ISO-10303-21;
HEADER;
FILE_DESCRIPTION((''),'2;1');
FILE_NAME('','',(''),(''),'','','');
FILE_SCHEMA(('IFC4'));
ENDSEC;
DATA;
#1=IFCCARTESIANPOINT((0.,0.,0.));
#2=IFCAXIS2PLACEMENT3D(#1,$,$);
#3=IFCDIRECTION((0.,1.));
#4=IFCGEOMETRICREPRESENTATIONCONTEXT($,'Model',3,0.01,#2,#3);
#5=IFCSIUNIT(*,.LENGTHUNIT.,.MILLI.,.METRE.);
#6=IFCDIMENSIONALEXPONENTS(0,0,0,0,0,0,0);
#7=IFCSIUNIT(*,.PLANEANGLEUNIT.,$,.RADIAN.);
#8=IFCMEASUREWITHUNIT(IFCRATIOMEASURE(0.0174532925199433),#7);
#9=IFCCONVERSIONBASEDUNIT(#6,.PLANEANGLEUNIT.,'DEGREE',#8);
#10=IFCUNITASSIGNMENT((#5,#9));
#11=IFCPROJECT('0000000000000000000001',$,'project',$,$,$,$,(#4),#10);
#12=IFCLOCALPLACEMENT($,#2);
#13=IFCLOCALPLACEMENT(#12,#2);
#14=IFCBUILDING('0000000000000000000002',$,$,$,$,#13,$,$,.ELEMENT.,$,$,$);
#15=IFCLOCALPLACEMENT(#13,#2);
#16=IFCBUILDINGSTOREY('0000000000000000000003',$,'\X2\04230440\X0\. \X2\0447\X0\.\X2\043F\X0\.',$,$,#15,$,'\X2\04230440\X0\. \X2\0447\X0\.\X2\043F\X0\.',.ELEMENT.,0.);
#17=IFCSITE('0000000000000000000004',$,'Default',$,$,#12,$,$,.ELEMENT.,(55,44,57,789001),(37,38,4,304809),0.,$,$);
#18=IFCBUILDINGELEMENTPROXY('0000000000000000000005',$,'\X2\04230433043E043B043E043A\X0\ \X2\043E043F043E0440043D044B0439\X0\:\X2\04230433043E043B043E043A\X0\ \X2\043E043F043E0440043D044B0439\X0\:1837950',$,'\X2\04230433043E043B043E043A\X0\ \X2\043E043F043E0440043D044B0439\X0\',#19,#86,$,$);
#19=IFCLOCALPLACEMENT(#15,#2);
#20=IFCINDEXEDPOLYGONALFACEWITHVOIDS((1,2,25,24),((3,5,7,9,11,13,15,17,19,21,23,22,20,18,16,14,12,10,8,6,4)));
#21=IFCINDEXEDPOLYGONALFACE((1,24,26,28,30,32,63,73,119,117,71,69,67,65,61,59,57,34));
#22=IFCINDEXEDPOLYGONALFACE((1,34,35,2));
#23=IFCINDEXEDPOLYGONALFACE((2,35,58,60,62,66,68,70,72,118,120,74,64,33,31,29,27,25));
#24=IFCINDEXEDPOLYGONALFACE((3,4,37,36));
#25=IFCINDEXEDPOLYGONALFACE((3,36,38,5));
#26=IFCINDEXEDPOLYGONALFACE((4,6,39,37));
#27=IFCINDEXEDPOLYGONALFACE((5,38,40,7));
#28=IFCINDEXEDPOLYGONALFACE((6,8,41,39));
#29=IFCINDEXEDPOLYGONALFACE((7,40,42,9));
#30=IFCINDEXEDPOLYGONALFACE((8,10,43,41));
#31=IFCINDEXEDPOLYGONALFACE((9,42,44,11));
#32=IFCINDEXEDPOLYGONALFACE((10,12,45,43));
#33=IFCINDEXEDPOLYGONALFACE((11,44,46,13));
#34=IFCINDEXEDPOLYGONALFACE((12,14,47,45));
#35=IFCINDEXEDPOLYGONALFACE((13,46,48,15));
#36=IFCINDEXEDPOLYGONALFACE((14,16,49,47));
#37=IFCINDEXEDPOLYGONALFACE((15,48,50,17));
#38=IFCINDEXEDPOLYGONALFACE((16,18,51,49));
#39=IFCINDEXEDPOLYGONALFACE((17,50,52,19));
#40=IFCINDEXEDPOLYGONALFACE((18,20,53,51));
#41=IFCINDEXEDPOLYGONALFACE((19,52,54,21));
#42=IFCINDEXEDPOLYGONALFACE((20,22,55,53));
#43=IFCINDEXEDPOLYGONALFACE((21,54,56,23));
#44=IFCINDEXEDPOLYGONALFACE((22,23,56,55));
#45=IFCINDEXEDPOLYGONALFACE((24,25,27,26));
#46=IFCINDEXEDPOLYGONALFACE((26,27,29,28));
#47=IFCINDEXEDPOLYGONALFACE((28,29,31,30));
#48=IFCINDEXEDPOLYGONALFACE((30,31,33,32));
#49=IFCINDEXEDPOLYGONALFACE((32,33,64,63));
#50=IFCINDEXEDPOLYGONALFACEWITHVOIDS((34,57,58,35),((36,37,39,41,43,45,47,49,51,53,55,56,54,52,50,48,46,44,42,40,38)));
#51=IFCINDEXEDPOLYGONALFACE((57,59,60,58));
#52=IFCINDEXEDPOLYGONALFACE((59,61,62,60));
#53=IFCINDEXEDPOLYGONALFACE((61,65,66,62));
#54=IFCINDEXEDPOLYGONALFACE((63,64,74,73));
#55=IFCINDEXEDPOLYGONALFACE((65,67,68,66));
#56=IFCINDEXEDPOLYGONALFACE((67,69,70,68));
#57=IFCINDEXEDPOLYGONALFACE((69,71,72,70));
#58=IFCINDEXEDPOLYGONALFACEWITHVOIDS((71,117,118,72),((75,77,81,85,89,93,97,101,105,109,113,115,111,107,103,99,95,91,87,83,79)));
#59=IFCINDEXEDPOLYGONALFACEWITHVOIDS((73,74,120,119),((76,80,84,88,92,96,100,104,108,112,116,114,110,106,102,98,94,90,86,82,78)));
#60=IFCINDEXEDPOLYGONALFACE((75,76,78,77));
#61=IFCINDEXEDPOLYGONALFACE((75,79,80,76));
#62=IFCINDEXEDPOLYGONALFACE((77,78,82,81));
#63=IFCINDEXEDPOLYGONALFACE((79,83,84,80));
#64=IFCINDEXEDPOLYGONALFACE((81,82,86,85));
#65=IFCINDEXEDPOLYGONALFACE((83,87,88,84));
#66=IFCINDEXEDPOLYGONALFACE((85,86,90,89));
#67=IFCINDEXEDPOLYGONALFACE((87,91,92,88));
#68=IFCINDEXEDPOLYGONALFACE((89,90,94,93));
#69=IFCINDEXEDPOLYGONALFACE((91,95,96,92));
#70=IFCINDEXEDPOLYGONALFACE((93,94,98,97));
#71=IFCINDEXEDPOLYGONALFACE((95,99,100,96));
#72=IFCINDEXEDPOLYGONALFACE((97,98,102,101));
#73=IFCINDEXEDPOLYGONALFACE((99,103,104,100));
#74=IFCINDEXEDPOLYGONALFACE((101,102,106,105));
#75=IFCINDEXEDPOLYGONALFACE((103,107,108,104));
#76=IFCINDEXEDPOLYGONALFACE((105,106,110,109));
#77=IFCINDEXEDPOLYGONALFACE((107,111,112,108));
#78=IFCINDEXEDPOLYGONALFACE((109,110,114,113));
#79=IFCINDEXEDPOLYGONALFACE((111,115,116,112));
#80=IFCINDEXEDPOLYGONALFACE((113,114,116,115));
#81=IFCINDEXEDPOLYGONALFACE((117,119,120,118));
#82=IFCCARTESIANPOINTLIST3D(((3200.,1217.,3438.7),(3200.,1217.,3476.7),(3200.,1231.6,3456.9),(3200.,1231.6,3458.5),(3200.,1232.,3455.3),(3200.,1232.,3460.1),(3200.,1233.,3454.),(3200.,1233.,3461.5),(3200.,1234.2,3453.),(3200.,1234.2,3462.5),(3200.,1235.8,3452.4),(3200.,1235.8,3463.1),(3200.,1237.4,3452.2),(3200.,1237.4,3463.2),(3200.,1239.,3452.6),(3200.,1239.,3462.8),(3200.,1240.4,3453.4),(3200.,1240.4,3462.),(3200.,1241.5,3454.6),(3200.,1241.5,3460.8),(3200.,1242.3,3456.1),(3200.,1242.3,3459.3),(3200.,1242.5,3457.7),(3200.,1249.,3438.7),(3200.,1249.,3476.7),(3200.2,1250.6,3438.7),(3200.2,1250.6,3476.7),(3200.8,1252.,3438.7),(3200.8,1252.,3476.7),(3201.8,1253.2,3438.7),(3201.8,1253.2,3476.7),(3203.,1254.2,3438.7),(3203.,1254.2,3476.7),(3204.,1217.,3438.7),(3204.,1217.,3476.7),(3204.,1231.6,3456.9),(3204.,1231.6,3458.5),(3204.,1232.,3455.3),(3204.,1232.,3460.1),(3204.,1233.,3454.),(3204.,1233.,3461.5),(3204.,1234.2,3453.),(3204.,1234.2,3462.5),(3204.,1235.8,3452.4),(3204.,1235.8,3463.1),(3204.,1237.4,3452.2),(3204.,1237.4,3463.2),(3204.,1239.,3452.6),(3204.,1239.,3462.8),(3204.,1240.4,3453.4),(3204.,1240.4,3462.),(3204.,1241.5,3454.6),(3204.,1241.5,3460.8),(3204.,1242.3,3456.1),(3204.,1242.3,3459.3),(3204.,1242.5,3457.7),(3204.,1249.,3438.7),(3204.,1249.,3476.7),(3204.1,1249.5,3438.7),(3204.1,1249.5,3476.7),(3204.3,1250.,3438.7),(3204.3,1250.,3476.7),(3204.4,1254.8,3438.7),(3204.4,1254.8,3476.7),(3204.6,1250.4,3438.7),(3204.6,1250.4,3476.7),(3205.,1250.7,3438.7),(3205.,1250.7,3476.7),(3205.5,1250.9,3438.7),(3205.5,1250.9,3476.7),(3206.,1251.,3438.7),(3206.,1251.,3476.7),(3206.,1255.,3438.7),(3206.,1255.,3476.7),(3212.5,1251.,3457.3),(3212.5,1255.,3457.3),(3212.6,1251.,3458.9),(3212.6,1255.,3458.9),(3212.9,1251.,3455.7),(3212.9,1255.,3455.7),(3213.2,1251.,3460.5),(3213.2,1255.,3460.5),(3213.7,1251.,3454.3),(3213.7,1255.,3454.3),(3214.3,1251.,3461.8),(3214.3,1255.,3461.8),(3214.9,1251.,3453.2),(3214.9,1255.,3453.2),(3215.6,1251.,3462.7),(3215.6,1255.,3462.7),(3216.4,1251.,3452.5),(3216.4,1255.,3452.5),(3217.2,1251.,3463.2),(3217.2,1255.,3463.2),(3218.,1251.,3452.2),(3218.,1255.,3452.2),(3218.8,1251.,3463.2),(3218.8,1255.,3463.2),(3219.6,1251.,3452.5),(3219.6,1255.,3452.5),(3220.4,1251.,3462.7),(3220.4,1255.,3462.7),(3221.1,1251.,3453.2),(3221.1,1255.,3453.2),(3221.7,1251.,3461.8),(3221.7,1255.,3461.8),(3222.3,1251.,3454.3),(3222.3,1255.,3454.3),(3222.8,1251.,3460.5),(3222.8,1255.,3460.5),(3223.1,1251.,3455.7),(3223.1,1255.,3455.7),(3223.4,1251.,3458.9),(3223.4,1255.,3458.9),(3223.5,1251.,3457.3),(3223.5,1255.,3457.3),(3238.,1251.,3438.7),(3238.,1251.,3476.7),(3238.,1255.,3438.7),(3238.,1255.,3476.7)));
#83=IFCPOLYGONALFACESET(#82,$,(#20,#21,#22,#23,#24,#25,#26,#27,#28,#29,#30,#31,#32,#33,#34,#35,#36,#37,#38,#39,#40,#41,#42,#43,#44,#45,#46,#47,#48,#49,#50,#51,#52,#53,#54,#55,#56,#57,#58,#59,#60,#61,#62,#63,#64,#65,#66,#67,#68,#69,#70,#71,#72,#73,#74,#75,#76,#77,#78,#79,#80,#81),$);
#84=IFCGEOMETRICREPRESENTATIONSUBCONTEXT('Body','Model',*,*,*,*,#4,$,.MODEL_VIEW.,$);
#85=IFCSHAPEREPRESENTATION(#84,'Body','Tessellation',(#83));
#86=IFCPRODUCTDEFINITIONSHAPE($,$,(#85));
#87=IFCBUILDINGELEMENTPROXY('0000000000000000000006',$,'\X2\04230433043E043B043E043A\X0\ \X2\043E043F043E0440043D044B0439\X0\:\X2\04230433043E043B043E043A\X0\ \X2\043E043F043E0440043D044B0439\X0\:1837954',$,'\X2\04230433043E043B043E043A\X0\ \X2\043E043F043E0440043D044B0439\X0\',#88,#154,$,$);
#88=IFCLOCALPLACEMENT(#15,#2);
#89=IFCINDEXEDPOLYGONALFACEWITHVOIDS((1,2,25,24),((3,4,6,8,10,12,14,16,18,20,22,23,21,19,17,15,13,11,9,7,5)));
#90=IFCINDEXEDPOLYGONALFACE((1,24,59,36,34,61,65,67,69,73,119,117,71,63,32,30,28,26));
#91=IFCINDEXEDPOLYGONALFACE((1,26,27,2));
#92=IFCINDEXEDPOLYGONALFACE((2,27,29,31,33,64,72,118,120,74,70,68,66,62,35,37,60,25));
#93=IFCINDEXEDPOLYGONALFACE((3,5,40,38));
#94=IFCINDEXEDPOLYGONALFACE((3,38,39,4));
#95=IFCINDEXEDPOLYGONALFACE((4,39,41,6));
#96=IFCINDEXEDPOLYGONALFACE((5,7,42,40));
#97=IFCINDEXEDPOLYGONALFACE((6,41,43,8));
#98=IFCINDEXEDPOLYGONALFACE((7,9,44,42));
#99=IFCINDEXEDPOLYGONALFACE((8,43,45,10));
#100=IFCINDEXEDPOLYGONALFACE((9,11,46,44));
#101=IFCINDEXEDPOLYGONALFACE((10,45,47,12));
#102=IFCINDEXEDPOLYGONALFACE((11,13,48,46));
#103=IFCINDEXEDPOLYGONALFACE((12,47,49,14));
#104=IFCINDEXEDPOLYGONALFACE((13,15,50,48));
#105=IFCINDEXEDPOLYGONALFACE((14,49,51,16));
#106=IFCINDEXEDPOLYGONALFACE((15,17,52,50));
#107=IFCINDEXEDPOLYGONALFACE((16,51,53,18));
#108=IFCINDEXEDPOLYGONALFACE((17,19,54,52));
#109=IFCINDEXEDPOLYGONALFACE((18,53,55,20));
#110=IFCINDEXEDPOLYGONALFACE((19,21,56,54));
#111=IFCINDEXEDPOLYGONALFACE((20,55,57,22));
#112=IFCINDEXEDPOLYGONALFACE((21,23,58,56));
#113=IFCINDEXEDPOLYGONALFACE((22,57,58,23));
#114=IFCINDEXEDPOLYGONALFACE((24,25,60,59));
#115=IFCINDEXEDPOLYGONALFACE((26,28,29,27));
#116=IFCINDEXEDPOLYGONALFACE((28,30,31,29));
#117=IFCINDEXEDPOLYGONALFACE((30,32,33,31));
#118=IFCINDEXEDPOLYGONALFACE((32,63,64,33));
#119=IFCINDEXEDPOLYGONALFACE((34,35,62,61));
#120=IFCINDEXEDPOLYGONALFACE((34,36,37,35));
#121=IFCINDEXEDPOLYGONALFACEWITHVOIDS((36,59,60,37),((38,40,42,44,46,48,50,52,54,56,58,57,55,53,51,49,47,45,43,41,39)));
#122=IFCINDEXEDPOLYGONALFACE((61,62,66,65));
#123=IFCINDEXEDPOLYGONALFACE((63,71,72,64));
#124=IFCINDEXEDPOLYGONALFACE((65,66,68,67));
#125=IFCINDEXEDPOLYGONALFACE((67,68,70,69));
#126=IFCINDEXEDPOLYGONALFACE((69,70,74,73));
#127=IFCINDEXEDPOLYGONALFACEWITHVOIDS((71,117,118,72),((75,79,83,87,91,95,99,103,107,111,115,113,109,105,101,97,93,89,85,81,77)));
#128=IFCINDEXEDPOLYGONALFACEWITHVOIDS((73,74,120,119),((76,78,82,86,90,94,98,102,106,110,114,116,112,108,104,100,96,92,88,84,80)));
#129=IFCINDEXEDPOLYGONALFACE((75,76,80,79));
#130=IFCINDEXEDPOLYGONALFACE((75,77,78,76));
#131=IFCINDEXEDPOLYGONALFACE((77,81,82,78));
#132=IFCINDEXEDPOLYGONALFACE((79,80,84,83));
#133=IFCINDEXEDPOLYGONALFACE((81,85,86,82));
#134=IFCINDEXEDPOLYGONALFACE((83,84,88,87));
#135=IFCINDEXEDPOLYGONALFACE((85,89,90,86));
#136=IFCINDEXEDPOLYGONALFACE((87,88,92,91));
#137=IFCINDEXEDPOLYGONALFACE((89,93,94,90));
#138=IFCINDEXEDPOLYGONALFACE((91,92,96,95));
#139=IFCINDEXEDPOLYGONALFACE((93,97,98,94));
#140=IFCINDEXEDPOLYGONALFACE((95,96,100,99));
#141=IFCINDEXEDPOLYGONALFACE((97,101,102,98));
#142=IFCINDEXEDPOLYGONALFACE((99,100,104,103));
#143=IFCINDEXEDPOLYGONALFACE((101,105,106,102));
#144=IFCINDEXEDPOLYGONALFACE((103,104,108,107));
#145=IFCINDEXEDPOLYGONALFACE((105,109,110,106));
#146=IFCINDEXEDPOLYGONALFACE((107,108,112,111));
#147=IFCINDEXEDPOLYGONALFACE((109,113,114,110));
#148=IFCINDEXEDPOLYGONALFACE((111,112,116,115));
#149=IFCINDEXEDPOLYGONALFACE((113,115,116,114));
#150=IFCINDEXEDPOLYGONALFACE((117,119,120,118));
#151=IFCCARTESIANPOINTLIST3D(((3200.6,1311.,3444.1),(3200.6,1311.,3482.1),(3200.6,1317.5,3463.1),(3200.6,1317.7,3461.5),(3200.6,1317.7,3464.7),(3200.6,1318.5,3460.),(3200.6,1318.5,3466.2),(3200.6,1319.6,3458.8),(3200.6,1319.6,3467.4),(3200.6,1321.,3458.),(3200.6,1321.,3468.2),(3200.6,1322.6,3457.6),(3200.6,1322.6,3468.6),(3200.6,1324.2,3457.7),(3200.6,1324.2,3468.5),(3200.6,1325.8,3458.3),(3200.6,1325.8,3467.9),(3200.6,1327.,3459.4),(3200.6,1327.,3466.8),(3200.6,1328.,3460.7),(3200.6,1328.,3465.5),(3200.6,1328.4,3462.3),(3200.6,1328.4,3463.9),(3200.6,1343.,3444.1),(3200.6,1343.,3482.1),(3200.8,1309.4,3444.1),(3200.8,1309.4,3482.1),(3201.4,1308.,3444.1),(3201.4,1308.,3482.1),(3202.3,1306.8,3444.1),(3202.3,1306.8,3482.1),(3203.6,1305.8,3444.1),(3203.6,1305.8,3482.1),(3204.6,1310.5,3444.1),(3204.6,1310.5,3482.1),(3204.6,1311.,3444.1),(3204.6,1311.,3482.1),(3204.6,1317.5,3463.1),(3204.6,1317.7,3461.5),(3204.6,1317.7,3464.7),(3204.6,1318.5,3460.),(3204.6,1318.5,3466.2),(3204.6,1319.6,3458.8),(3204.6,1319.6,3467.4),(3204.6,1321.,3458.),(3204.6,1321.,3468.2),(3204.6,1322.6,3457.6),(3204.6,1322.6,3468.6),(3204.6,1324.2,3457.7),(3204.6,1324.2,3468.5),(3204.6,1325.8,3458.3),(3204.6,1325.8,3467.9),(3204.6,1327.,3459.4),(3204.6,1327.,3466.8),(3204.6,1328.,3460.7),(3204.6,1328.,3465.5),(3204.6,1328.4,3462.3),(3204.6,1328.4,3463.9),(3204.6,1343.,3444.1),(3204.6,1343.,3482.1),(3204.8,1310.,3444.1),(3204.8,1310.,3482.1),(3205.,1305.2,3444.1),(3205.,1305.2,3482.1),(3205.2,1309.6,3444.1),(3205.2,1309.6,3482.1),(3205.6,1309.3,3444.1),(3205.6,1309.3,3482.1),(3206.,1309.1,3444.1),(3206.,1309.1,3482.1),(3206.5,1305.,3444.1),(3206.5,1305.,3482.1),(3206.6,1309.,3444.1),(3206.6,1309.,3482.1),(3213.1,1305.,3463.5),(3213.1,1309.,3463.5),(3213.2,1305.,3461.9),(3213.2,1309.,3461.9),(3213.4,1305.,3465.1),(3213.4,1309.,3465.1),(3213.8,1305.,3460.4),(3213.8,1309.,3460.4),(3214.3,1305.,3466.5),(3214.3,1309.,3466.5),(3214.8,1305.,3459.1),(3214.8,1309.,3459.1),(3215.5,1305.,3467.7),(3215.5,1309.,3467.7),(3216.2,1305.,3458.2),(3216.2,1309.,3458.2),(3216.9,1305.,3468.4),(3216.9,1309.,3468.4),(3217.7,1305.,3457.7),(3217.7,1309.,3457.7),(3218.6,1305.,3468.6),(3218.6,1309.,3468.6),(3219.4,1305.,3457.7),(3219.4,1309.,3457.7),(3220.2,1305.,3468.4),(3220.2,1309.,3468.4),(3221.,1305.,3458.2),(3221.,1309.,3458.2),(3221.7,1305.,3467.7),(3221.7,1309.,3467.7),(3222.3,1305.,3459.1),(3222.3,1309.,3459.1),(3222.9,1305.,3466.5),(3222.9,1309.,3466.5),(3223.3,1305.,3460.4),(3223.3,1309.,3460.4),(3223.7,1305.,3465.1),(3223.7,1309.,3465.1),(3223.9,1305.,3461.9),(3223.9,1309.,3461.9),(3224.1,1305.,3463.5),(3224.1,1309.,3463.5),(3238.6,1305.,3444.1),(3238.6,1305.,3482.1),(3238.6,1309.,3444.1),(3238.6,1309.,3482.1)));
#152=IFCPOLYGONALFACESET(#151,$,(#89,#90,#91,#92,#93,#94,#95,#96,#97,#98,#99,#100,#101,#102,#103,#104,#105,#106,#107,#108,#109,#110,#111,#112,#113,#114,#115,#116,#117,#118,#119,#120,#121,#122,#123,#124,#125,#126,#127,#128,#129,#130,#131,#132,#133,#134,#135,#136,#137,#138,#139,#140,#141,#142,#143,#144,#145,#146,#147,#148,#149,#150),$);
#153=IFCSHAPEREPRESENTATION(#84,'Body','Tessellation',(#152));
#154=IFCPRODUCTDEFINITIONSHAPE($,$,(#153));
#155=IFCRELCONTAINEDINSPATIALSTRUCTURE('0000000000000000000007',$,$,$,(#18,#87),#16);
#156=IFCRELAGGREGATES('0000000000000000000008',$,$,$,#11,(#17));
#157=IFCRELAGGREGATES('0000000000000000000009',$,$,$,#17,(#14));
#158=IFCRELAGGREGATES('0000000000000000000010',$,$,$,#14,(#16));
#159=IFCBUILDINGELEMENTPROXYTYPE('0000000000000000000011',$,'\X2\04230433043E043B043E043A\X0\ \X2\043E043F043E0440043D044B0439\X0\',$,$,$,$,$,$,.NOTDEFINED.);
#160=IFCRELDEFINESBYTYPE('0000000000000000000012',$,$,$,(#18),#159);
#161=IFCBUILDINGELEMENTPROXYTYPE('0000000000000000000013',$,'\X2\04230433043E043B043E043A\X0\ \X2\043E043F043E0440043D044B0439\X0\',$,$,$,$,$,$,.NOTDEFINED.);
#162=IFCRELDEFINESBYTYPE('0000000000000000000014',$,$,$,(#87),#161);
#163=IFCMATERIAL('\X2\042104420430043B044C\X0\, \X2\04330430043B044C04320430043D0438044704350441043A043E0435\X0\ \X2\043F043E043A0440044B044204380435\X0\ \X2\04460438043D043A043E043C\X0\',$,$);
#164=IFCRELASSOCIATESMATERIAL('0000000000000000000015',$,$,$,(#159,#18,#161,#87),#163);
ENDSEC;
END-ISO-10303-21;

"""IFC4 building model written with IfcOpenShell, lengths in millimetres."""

from ifc_helpers import new_model, entity, si_unit, converted_unit, direction, frame, frame_2d, origin, place, context, subcontext, project, spatial, polyline, circle_curve, parameter, trimmed, segment, composite_curve, circle, outline, extrude, source, transform, mapped, material, type_object, type_shapes, element, save


model = new_model("IFC4")

# Units and contexts
model_context = context("Model", 3, precision=0.01, world=origin(), true_north=direction((0.0, 1.0)))
body_context = subcontext(model_context, "Body", "Model", "MODEL_VIEW")
ifc_project = project(units=[si_unit("LENGTHUNIT", "METRE", prefix="MILLI"), converted_unit("PLANEANGLEUNIT", "DEGREE", entity("IfcRatioMeasure", 0.0174532925199433), si_unit("PLANEANGLEUNIT", "RADIAN"), dimensions=[0, 0, 0, 0, 0, 0, 0])], contexts=[model_context])

# Site, building, storey
site_placement = place(None, origin())
site = spatial("IfcSite", under=ifc_project, at=site_placement, Name="Default", CompositionType="ELEMENT", RefLatitude=(55, 44, 57, 789001), RefLongitude=(37, 38, 4, 304809), RefElevation=0.0)
building_placement = place(site_placement, origin())
building = spatial("IfcBuilding", under=site, at=building_placement, CompositionType="ELEMENT")
storey_placement = place(building_placement, origin())
storey = spatial("IfcBuildingStorey", under=building, at=storey_placement, Name="Ур. ч.п.", LongName="Ур. ч.п.", CompositionType="ELEMENT", Elevation=0.0)

# Building element proxies, openings
ifc_material = material(Name="Сталь, гальваническое покрытие цинком")
building_element_proxy_type_1 = type_object("IfcBuildingElementProxyType", Name="Уголок опорный", material=ifc_material)
shared_shape_1 = source(origin(), body_context, "Body", "SweptSolid", [
    extrude(outline(composite_curve([segment(polyline([(-6.0, -12.0), (26.0, -12.0)]), True, "CONTINUOUS"), segment(polyline([(26.0, -12.0), (26.0, -8.0)]), True, "CONTINUOUS"), segment(polyline([(26.0, -8.0), (-6.0, -8.0)]), True, "CONTINUOUS"), segment(trimmed(circle_curve(frame_2d((-6.0, -6.0), x_axis=(0.0, -1.0)), 2.0), [parameter(270.0)], [parameter(0.0)], True, "PARAMETER"), False, "CONTINUOUS"), segment(polyline([(-8.0, -6.0), (-8.0, 26.0)]), True, "CONTINUOUS"), segment(polyline([(-8.0, 26.0), (-12.0, 26.0)]), True, "CONTINUOUS"), segment(polyline([(-12.0, 26.0), (-12.0, -6.0)]), True, "CONTINUOUS"), segment(trimmed(circle_curve(frame_2d((-6.0, -6.0), x_axis=(0.0, -1.0)), 6.0), [parameter(270.0)], [parameter(360.0)], True, "PARAMETER"), True, "CONTINUOUS")], self_intersect=False)), frame((12.0, -19.0, 12.0), z_axis=(0.0, 1.0, 0.0), x_axis=(0.0, 0.0, 1.0)), (0.0, 0.0, 1.0), 38.0),
])
type_shapes(building_element_proxy_type_1, [shared_shape_1])
proxy_1_placement = place(storey_placement, frame((3200.0, 1255.0, 3457.7), z_axis=(0.0, -1.0, 0.0), x_axis=(1.0, 0.0, 0.0)))
proxy_1 = element("IfcBuildingElementProxy", 1, at=proxy_1_placement, inside=storey, type_object=building_element_proxy_type_1, material=ifc_material, Name="Уголок опорный:Уголок опорный:1837950", ObjectType="Уголок опорный", context=body_context, shape_type="MappedRepresentation", body=[
    mapped(shared_shape_1, transform((0.0, 0.0, 0.0), scale=1.0)),
])
opening_1_placement = place(storey_placement, frame((3200.0, 1255.0, 3457.7), z_axis=(0.0, 0.0, -1.0), x_axis=(1.0, 0.0, 0.0)))
element("IfcOpeningElement", 2, at=opening_1_placement, cuts=proxy_1, ObjectType="Opening", PredefinedType="OPENING", context=body_context, shape_type="SweptSolid", body=[
    extrude(circle(Radius=5.5, at=frame_2d((0.0, 0.0), x_axis=(1.0, 0.0))), frame((4.0, 18.0, 0.0), z_axis=(-1.0, 0.0, 0.0), x_axis=(0.0, -1.0, 0.0)), (0.0, 0.0, 1.0), 4.0),
])
opening_2_placement = place(storey_placement, frame((3200.0, 1255.0, 3457.7), z_axis=(0.0, 0.0, -1.0), x_axis=(1.0, 0.0, 0.0)))
element("IfcOpeningElement", 3, at=opening_2_placement, cuts=proxy_1, ObjectType="Opening", PredefinedType="OPENING", context=body_context, shape_type="SweptSolid", body=[
    extrude(circle(Radius=5.5, at=frame_2d((0.0, 0.0), x_axis=(1.0, 0.0))), frame((18.0, 0.0, 0.0), z_axis=(0.0, 1.0, 0.0), x_axis=(0.0, 0.0, 1.0)), (0.0, 0.0, 1.0), 4.0),
])
building_element_proxy_type_2 = type_object("IfcBuildingElementProxyType", Name="Уголок опорный", material=ifc_material)
shared_shape_2 = source(origin(), body_context, "Body", "SweptSolid", [
    extrude(outline(composite_curve([segment(polyline([(-6.0, -12.0), (26.0, -12.0)]), True, "CONTINUOUS"), segment(polyline([(26.0, -12.0), (26.0, -8.0)]), True, "CONTINUOUS"), segment(polyline([(26.0, -8.0), (-6.0, -8.0)]), True, "CONTINUOUS"), segment(trimmed(circle_curve(frame_2d((-6.0, -6.0), x_axis=(0.0, -1.0)), 2.0), [parameter(270.0)], [parameter(0.0)], True, "PARAMETER"), False, "CONTINUOUS"), segment(polyline([(-8.0, -6.0), (-8.0, 26.0)]), True, "CONTINUOUS"), segment(polyline([(-8.0, 26.0), (-12.0, 26.0)]), True, "CONTINUOUS"), segment(polyline([(-12.0, 26.0), (-12.0, -6.0)]), True, "CONTINUOUS"), segment(trimmed(circle_curve(frame_2d((-6.0, -6.0), x_axis=(0.0, -1.0)), 6.0), [parameter(270.0)], [parameter(360.0)], True, "PARAMETER"), True, "CONTINUOUS")], self_intersect=False)), frame((12.0, -19.0, 12.0), z_axis=(0.0, 1.0, 0.0), x_axis=(0.0, 0.0, 1.0)), (0.0, 0.0, 1.0), 38.0),
])
type_shapes(building_element_proxy_type_2, [shared_shape_2])
proxy_2_placement = place(storey_placement, frame((3200.6, 1305.0, 3463.1), z_axis=(0.0, 1.0, 0.0), x_axis=(1.0, 0.0, 0.0)))
proxy_2 = element("IfcBuildingElementProxy", 4, at=proxy_2_placement, inside=storey, type_object=building_element_proxy_type_2, material=ifc_material, Name="Уголок опорный:Уголок опорный:1837954", ObjectType="Уголок опорный", context=body_context, shape_type="MappedRepresentation", body=[
    mapped(shared_shape_2, transform((0.0, 0.0, 0.0), scale=1.0)),
])
opening_3_placement = place(storey_placement, frame((3200.6, 1305.0, 3463.1), z_axis=(0.0, 0.0, -1.0), x_axis=(1.0, 0.0, 0.0)))
element("IfcOpeningElement", 5, at=opening_3_placement, cuts=proxy_2, ObjectType="Opening", PredefinedType="OPENING", context=body_context, shape_type="SweptSolid", body=[
    extrude(circle(Radius=5.5, at=frame_2d((0.0, 0.0), x_axis=(1.0, 0.0))), frame((4.0, -18.0, 0.0), z_axis=(-1.0, 0.0, 0.0), x_axis=(0.0, 1.0, 0.0)), (0.0, 0.0, 1.0), 4.0),
])
opening_4_placement = place(storey_placement, frame((3200.6, 1305.0, 3463.1), z_axis=(0.0, 0.0, -1.0), x_axis=(1.0, 0.0, 0.0)))
element("IfcOpeningElement", 6, at=opening_4_placement, cuts=proxy_2, ObjectType="Opening", PredefinedType="OPENING", context=body_context, shape_type="SweptSolid", body=[
    extrude(circle(Radius=5.5, at=frame_2d((0.0, 0.0), x_axis=(1.0, 0.0))), frame((18.0, 0.0, 0.0), z_axis=(0.0, -1.0, 0.0), x_axis=(0.0, 0.0, -1.0)), (0.0, 0.0, 1.0), 4.0),
])

save(model, "model.ifc")
